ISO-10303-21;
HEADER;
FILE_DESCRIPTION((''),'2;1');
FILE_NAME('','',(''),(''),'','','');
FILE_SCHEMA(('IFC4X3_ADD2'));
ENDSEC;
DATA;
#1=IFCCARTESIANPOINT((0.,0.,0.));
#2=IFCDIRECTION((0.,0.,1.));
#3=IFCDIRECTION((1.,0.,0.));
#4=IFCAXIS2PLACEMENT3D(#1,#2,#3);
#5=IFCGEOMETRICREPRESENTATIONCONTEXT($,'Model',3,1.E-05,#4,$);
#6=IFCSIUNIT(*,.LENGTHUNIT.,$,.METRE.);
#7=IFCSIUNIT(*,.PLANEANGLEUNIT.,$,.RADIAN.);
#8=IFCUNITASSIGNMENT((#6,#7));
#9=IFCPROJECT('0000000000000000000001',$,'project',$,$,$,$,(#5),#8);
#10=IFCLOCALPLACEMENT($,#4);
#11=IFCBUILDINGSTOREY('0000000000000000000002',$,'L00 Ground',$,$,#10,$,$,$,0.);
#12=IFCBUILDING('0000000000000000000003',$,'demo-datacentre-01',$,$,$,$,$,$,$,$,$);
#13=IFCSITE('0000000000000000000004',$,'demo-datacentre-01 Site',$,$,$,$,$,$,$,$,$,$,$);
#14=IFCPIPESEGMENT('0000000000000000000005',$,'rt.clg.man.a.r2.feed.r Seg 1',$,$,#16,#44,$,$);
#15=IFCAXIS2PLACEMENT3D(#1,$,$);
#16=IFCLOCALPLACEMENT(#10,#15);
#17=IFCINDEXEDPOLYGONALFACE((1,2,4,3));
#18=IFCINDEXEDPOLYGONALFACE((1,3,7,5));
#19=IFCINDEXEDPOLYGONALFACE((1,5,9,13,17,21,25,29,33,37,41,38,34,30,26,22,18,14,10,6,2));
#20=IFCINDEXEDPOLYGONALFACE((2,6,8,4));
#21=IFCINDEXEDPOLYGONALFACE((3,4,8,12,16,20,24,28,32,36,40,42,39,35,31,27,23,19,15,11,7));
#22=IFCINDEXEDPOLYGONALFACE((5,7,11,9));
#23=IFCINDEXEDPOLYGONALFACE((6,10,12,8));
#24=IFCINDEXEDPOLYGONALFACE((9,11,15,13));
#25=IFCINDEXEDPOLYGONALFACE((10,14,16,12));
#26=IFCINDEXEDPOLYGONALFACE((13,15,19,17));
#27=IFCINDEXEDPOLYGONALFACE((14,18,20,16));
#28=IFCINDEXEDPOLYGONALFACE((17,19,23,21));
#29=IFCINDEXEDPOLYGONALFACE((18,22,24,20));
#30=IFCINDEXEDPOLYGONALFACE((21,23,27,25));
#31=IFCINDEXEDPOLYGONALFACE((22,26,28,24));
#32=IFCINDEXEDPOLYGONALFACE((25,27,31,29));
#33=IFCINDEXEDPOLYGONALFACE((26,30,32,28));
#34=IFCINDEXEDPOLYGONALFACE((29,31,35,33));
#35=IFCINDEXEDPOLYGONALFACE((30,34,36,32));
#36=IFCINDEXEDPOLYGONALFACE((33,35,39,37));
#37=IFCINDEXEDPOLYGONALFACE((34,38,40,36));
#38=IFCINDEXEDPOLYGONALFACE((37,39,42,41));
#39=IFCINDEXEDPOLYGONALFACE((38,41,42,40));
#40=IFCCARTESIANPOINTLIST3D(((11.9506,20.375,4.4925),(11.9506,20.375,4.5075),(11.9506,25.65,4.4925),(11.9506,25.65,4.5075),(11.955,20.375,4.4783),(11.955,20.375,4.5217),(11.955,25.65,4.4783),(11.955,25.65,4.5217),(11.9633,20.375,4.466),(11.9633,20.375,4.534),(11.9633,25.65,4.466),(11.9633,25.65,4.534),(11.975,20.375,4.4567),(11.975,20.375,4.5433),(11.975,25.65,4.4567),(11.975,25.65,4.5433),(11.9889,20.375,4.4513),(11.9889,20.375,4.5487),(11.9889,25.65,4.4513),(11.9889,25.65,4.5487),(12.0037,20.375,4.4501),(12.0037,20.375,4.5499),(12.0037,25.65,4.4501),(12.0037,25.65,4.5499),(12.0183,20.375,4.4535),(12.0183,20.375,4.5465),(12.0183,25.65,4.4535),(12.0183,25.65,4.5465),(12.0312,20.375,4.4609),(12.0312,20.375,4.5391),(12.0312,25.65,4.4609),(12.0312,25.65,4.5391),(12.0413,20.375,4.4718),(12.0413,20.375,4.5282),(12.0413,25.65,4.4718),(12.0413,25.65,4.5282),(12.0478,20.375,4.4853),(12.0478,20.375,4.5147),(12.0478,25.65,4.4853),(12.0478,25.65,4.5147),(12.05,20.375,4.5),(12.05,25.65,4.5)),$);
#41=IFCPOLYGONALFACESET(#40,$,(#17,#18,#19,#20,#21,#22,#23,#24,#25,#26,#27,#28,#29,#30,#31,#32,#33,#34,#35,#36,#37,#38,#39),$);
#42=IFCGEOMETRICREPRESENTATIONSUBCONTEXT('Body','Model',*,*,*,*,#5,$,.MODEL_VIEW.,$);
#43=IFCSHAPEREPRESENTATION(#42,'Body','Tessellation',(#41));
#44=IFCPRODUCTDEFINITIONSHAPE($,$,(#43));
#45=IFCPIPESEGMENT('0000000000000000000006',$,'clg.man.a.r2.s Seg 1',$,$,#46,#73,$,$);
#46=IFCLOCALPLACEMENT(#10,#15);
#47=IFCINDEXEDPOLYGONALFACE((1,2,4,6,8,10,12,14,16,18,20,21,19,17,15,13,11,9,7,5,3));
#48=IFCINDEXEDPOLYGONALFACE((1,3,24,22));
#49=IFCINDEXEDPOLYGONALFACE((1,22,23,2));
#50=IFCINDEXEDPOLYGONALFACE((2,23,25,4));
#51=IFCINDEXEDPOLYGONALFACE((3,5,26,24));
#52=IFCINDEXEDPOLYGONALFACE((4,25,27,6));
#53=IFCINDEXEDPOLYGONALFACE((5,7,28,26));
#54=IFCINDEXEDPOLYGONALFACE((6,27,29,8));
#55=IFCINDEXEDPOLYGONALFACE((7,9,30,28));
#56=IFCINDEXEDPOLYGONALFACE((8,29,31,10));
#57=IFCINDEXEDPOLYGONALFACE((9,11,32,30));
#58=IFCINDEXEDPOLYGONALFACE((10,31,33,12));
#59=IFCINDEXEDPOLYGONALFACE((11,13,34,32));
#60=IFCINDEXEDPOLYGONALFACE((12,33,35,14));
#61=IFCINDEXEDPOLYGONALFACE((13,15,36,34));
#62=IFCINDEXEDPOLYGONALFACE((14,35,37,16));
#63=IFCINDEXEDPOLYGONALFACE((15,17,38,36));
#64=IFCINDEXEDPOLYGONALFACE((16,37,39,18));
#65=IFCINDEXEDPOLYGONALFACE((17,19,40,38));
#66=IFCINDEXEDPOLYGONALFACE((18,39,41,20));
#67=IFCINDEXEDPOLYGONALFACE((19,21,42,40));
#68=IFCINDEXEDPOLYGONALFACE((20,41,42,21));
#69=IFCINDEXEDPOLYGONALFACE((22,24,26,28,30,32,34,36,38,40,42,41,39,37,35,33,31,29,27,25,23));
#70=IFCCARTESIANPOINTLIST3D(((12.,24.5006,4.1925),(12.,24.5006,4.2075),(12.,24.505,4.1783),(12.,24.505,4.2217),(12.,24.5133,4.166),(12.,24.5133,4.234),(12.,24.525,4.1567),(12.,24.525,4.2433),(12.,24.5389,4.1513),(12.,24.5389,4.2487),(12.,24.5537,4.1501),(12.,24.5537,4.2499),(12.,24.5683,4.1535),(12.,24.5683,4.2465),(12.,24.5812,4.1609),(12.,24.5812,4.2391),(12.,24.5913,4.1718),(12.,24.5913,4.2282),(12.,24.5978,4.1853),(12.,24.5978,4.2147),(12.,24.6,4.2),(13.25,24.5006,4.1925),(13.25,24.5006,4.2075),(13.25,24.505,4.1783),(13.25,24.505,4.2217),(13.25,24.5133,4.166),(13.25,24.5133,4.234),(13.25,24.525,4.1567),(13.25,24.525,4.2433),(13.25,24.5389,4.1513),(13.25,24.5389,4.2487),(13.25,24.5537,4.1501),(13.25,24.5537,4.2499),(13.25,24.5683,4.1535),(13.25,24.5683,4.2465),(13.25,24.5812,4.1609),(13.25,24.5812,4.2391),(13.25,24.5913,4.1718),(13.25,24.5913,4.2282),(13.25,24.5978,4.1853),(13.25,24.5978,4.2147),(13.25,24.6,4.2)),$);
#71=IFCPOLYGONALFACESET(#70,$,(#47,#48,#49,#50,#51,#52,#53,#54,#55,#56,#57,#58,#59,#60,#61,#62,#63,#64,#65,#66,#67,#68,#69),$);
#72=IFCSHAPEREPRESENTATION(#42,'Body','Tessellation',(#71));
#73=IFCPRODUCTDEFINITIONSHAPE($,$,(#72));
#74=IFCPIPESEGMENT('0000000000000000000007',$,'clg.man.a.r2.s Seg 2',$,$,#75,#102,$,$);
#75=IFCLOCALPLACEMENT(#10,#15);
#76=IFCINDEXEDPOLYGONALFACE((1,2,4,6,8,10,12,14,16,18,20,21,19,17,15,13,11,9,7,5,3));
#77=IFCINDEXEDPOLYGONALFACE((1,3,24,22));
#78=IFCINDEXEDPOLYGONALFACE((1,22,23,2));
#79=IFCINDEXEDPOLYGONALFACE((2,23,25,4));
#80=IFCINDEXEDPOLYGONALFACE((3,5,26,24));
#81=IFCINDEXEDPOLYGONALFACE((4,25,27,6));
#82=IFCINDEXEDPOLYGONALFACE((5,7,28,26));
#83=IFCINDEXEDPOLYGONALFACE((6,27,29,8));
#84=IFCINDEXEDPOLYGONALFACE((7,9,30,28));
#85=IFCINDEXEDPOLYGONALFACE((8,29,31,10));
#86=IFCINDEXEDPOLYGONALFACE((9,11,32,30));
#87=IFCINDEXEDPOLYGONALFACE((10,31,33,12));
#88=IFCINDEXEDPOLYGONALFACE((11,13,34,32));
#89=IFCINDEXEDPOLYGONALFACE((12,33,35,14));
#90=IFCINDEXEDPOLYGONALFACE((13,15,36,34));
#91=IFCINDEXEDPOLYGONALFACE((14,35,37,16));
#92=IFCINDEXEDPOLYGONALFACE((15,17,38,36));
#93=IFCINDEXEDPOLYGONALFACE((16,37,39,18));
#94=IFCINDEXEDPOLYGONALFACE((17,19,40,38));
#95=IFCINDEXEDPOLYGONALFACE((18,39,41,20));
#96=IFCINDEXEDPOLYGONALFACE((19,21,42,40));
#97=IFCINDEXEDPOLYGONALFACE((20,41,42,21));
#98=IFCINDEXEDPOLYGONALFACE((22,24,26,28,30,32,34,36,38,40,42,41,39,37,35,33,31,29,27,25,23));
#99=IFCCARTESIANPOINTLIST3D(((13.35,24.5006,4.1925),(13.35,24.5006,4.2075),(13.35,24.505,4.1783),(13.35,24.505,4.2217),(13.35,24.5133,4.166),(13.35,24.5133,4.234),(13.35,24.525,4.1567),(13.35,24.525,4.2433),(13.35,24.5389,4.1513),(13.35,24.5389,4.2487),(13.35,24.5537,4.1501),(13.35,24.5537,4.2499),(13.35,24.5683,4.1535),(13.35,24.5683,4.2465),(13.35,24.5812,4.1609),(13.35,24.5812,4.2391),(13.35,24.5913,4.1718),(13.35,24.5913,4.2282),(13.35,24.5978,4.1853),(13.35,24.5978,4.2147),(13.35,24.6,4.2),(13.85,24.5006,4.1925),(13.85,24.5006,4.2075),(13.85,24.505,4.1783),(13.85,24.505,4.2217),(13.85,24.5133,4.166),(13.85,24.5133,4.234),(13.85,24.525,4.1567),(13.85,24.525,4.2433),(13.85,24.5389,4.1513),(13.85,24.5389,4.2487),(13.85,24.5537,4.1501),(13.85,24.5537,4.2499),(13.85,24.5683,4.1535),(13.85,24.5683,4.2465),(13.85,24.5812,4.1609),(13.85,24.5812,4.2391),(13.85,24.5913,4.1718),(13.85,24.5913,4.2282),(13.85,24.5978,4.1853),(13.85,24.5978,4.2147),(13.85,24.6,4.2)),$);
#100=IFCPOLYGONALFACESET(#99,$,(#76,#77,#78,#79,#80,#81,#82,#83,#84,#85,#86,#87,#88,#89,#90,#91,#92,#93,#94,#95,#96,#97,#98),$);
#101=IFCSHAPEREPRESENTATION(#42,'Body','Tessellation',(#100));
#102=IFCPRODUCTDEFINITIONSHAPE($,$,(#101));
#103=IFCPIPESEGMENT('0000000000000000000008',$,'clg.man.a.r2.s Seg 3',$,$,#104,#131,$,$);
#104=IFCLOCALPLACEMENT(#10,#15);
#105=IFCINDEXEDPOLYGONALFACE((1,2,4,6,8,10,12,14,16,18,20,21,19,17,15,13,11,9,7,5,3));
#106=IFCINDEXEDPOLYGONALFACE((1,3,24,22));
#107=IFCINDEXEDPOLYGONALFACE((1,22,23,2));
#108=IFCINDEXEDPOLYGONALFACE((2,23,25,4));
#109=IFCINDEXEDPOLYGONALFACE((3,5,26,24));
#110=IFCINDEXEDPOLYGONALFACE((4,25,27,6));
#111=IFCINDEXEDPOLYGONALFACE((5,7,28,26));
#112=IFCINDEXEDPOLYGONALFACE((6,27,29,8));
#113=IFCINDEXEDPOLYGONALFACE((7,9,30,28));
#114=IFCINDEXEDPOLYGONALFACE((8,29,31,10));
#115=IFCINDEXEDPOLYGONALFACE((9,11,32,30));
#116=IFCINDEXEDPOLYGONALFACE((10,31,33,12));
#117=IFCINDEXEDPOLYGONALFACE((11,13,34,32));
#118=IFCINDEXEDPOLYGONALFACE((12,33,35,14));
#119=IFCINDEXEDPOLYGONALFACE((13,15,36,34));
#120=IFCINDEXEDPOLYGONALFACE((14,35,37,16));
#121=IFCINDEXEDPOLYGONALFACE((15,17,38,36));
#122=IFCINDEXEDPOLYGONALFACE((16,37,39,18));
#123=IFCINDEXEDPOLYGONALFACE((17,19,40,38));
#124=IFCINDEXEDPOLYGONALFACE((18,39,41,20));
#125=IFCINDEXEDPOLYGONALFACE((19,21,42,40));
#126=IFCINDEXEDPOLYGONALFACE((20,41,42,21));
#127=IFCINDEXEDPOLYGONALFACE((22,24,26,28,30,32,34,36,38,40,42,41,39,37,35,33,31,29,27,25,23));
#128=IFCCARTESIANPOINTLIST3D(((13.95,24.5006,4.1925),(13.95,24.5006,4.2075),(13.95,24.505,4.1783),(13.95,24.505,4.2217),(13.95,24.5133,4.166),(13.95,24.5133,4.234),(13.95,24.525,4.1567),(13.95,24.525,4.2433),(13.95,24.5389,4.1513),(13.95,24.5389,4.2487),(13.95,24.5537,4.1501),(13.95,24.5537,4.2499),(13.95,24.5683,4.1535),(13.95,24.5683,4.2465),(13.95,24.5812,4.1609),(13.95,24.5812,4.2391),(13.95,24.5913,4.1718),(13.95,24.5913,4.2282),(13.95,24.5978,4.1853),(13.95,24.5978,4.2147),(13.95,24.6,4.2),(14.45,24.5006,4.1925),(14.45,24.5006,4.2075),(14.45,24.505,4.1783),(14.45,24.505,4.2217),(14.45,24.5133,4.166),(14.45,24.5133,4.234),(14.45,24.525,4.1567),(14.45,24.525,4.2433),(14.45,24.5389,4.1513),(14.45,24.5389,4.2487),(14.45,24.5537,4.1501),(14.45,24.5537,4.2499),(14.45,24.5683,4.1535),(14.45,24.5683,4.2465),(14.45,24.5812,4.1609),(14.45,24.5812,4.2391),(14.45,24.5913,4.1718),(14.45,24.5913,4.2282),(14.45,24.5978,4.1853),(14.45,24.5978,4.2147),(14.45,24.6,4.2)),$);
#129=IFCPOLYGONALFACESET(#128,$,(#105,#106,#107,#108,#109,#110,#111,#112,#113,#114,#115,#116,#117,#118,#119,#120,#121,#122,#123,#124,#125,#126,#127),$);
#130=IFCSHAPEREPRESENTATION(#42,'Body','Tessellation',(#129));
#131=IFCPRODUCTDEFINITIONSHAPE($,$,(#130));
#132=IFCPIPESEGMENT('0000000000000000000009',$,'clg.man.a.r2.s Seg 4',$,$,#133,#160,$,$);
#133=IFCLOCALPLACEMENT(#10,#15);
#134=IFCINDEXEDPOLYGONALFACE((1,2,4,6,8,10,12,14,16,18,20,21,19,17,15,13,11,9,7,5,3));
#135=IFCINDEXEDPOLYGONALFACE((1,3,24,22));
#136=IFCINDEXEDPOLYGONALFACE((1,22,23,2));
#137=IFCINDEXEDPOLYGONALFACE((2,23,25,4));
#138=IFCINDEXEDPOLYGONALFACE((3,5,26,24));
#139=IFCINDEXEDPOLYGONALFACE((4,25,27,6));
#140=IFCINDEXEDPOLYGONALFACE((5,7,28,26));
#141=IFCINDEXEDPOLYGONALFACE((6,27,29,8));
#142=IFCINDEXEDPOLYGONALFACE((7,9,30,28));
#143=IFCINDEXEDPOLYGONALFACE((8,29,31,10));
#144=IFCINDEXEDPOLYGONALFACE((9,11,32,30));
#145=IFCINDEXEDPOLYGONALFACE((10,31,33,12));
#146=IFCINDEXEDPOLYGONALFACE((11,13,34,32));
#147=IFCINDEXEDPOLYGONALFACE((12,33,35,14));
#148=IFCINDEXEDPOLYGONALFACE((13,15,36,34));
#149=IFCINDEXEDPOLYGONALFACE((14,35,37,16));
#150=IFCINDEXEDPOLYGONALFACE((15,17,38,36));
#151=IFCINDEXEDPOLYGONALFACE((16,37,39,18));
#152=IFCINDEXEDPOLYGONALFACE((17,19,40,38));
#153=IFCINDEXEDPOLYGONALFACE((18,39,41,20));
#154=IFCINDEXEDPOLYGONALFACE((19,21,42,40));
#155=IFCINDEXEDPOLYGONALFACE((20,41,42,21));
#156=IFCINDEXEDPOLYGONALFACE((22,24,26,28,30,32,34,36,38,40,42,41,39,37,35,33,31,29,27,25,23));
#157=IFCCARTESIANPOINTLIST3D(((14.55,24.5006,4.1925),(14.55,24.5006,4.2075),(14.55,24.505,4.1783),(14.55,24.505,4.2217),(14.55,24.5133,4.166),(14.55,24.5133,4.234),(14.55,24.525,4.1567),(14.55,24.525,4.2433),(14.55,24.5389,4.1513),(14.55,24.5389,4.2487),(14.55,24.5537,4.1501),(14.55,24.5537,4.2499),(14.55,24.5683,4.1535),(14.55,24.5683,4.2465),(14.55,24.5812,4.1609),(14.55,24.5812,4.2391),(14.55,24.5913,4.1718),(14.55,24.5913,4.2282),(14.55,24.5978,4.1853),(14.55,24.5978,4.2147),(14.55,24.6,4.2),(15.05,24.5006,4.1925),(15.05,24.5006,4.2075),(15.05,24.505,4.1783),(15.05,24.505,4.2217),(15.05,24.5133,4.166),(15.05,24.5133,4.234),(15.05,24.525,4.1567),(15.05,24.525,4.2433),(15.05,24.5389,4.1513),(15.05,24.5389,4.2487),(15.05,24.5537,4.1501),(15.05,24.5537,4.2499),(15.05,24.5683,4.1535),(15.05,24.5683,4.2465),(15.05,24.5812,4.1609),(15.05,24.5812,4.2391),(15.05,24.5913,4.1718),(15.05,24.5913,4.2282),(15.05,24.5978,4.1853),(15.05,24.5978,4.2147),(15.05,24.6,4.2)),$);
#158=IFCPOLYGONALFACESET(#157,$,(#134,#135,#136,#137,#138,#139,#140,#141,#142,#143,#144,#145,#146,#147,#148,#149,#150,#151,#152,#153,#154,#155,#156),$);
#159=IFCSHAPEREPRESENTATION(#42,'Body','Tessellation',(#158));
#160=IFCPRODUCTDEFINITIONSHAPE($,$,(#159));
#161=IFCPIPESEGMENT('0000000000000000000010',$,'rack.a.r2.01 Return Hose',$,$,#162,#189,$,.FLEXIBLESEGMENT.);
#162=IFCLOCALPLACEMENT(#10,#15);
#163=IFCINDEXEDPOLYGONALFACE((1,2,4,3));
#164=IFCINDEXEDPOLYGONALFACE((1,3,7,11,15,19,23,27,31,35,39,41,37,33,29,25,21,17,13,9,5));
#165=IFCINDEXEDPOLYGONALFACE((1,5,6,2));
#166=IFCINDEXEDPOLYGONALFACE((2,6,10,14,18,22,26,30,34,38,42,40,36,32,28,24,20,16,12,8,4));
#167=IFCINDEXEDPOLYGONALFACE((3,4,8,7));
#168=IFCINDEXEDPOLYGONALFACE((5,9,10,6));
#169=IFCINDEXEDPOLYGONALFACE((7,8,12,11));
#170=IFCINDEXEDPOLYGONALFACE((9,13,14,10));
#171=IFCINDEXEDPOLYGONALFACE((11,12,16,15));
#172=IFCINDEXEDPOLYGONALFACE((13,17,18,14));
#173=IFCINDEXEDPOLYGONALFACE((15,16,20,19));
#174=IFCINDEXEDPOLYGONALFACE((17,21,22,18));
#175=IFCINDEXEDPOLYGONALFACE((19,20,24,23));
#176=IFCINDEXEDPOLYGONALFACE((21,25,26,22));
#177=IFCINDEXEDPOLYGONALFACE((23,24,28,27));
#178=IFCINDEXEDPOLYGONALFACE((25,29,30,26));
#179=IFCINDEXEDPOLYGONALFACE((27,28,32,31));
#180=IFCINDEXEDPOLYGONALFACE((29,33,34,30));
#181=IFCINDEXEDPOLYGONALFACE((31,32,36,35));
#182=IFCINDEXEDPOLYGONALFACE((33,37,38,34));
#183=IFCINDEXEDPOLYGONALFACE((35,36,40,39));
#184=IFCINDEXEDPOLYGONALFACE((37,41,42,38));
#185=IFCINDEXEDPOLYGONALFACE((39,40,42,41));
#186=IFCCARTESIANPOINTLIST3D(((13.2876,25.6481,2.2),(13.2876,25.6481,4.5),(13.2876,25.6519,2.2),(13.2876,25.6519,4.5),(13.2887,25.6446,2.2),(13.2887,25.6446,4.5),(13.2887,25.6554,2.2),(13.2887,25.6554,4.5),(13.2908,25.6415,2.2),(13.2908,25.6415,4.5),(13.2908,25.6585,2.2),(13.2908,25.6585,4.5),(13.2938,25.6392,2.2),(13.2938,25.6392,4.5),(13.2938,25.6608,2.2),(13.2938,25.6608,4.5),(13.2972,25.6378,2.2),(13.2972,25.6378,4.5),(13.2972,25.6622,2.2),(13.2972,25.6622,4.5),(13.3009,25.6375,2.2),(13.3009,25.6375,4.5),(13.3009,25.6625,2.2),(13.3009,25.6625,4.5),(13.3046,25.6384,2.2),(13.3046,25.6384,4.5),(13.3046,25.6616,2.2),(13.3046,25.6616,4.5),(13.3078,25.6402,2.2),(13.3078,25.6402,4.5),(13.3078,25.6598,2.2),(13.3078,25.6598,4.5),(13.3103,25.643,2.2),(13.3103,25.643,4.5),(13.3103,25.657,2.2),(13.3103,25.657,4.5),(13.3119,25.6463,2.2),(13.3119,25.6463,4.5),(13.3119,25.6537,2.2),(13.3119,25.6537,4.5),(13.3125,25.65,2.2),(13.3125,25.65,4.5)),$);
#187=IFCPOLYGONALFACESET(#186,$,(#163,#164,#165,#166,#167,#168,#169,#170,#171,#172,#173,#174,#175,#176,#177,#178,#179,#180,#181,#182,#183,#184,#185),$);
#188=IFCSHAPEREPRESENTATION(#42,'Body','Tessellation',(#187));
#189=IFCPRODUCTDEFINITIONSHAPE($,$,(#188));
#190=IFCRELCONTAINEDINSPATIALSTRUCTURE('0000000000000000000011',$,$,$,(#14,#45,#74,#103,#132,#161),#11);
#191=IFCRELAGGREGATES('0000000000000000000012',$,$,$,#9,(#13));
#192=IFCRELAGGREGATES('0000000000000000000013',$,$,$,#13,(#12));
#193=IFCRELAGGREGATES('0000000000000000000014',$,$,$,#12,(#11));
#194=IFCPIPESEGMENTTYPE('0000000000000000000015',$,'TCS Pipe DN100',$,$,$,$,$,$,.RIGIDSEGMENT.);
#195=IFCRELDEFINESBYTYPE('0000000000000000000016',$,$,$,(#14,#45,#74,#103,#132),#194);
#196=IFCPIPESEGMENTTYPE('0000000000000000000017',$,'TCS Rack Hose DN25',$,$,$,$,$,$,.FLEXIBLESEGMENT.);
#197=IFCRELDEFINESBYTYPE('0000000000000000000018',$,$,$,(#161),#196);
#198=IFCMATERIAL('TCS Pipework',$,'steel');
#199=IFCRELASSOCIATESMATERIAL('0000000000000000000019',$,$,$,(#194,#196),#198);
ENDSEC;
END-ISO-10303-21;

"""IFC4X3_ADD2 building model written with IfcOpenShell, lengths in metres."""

from ifc_helpers import new_model, si_unit, frame, origin_with_axes, place, context, subcontext, project, spatial, circle, extrude, material, type_object, element, save


model = new_model("IFC4X3_ADD2")

# Units and contexts
model_context = context("Model", 3, precision=1e-05, world=origin_with_axes())
body_context = subcontext(model_context, "Body", "Model", "MODEL_VIEW")
ifc_project = project(units=[si_unit("LENGTHUNIT", "METRE"), si_unit("PLANEANGLEUNIT", "RADIAN")], contexts=[model_context])

# Site, building, storey
site = spatial("IfcSite", under=ifc_project, Name="demo-datacentre-01 Site")
building = spatial("IfcBuilding", under=site, Name="demo-datacentre-01")
storey_placement = place(None, origin_with_axes())
storey = spatial("IfcBuildingStorey", under=building, at=storey_placement, Name="L00 Ground", Elevation=0.0)

# Shared definitions
ifc_material = material(Name="TCS Pipework", Category="steel")

# Pipe segments
pipe_segment_type_1 = type_object("IfcPipeSegmentType", Name="TCS Pipe DN100", PredefinedType="RIGIDSEGMENT", material=ifc_material)
pipe_segment_1_placement = place(storey_placement, frame((12.0, 25.65, 4.5), z_axis=(0.0, -1.0, 0.0), x_axis=(1.0, 0.0, 0.0)))
element("IfcPipeSegment", 1, at=pipe_segment_1_placement, inside=storey, type_object=pipe_segment_type_1, Name="rt.clg.man.a.r2.feed.r Seg 1", context=body_context, shape_type="SweptSolid", body=[
    extrude(circle(Radius=0.05), origin_with_axes(), (0.0, 0.0, 1.0), 5.275),
])
pipe_segment_2_placement = place(storey_placement, frame((12.0, 24.55, 4.2), z_axis=(1.0, 0.0, 0.0), x_axis=(0.0, 1.0, 0.0)))
element("IfcPipeSegment", 2, at=pipe_segment_2_placement, inside=storey, type_object=pipe_segment_type_1, Name="clg.man.a.r2.s Seg 1", context=body_context, shape_type="SweptSolid", body=[
    extrude(circle(Radius=0.05), origin_with_axes(), (0.0, 0.0, 1.0), 1.25),
])
for number, where, z_axis, x_axis, name in (
    (3, (13.35, 24.55, 4.2), (1.0, 0.0, 0.0), (0.0, 1.0, 0.0), "clg.man.a.r2.s Seg 2"),
    (4, (13.95, 24.55, 4.2), (1.0, 0.0, 0.0), (0.0, 1.0, 0.0), "clg.man.a.r2.s Seg 3"),
):
    element("IfcPipeSegment", number, at=place(storey_placement, frame(where, z_axis=z_axis, x_axis=x_axis)), inside=storey, type_object=pipe_segment_type_1, Name=name, context=body_context, shape_type="SweptSolid", body=[
        extrude(circle(Radius=0.05), origin_with_axes(), (0.0, 0.0, 1.0), 0.5),
    ])
pipe_segment_3_placement = place(storey_placement, frame((14.55, 24.55, 4.2), z_axis=(1.0, 0.0, 0.0), x_axis=(0.0, 1.0, 0.0)))
element("IfcPipeSegment", 5, at=pipe_segment_3_placement, inside=storey, type_object=pipe_segment_type_1, Name="clg.man.a.r2.s Seg 4", context=body_context, shape_type="SweptSolid", body=[
    extrude(circle(Radius=0.05), origin_with_axes(), (0.0, 0.0, 1.0), 0.5),
])
pipe_segment_type_2 = type_object("IfcPipeSegmentType", Name="TCS Rack Hose DN25", PredefinedType="FLEXIBLESEGMENT", material=ifc_material)
for number, where, z_axis, x_axis, name in (
    (6, (13.3, 25.65, 4.5), (0.0, 0.0, -1.0), (1.0, 0.0, 0.0), "rack.a.r2.01 Return Hose"),
):
    element("IfcPipeSegment", number, at=place(storey_placement, frame(where, z_axis=z_axis, x_axis=x_axis)), inside=storey, type_object=pipe_segment_type_2, Name=name, PredefinedType="FLEXIBLESEGMENT", context=body_context, shape_type="SweptSolid", body=[
        extrude(circle(Radius=0.0125), origin_with_axes(), (0.0, 0.0, 1.0), 2.3),
    ])

save(model, "model.ifc")
